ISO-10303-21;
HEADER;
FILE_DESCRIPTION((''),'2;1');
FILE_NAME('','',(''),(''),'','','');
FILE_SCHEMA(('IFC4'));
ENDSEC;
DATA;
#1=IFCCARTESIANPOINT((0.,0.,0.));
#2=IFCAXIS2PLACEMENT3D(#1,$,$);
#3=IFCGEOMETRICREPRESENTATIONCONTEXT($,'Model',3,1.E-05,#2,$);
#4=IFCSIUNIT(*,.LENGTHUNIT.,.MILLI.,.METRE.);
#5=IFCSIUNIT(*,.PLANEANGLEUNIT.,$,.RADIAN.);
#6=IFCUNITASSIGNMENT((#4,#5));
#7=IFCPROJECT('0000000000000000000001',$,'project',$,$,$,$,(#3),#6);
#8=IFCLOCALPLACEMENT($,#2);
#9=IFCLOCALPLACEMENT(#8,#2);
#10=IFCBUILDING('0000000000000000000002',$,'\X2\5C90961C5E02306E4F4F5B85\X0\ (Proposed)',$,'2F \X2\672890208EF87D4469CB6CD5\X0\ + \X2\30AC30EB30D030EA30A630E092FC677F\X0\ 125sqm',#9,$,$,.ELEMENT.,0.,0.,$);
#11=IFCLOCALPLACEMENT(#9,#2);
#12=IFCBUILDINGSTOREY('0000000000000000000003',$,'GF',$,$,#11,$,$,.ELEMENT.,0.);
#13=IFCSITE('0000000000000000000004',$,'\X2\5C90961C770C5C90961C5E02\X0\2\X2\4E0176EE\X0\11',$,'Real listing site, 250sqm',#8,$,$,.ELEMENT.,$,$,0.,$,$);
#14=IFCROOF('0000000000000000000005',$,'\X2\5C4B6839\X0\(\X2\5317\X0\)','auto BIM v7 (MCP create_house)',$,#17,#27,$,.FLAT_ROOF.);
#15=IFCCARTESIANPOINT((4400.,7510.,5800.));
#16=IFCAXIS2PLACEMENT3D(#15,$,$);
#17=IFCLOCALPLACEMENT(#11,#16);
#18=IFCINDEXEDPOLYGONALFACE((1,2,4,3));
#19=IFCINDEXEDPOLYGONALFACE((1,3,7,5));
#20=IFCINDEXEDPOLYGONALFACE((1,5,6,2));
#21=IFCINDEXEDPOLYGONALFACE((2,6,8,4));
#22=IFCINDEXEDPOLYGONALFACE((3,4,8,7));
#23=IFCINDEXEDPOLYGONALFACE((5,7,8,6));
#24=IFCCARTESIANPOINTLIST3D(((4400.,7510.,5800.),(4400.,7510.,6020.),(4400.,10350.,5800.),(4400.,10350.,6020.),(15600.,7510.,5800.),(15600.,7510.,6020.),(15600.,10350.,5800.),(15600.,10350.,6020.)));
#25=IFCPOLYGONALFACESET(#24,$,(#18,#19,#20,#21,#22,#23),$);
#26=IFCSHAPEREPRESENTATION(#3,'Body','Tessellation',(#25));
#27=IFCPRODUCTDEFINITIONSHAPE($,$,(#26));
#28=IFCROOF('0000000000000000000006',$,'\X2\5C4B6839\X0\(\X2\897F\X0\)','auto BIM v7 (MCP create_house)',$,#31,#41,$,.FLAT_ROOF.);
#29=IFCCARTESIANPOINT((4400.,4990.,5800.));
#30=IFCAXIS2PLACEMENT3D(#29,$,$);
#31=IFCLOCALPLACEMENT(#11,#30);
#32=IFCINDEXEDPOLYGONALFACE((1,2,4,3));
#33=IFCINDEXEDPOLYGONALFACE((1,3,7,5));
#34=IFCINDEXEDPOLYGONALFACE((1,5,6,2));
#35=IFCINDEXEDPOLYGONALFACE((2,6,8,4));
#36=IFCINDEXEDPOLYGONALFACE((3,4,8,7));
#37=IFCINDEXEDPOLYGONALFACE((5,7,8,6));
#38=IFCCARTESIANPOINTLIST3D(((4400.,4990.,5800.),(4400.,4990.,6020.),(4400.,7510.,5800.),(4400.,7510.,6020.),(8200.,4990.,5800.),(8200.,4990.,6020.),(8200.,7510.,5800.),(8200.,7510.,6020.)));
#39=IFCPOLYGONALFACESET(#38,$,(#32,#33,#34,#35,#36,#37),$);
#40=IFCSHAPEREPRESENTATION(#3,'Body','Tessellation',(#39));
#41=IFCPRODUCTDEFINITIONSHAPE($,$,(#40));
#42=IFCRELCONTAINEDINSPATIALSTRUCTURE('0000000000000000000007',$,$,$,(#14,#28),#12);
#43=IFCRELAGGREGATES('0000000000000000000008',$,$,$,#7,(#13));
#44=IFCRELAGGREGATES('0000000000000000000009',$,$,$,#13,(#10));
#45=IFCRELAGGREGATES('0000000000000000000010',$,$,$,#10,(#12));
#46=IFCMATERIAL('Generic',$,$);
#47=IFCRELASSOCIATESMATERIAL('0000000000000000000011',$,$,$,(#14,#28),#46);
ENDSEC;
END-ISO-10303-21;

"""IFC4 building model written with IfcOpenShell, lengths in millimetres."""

from ifc_helpers import new_model, si_unit, frame, frame_2d, origin, place, context, project, spatial, rectangle, extrude, material, element, save


model = new_model("IFC4")

# Units and contexts
model_context = context("Model", 3, precision=1e-05, world=origin())
ifc_project = project(units=[si_unit("LENGTHUNIT", "METRE", prefix="MILLI"), si_unit("PLANEANGLEUNIT", "RADIAN")], contexts=[model_context])

# Site, building, storey
site_placement = place(None, origin())
site = spatial("IfcSite", under=ifc_project, at=site_placement, Name="岐阜県岐阜市2丁目11", ObjectType="Real listing site, 250sqm", CompositionType="ELEMENT", RefElevation=0.0)
building_placement = place(site_placement, origin())
building = spatial("IfcBuilding", under=site, at=building_placement, Name="岐阜市の住宅 (Proposed)", ObjectType="2F 木造軸組構法 + ガルバリウム鋼板 125sqm", CompositionType="ELEMENT", ElevationOfRefHeight=0.0, ElevationOfTerrain=0.0)
storey_placement = place(building_placement, origin())
storey = spatial("IfcBuildingStorey", under=building, at=storey_placement, Name="GF", CompositionType="ELEMENT", Elevation=0.0)

# Shared definitions
ifc_material = material(Name="Generic")

# Roofs
roof_1_placement = place(storey_placement, frame((4400.0, 7510.0, 5800.0)))
element("IfcRoof", 1, at=roof_1_placement, inside=storey, material=ifc_material, Name="屋根(北)", Description="auto BIM v7 (MCP create_house)", PredefinedType="FLAT_ROOF", context=model_context, shape_type="SweptSolid", body=[
    extrude(rectangle(XDim=11200.0, YDim=2840.0, at=frame_2d((5600.0, 1420.0))), frame((4400.0, 7510.0, 5800.0)), (0.0, 0.0, 1.0), 220.0),
])
roof_2_placement = place(storey_placement, frame((4400.0, 4990.0, 5800.0)))
element("IfcRoof", 2, at=roof_2_placement, inside=storey, material=ifc_material, Name="屋根(西)", Description="auto BIM v7 (MCP create_house)", PredefinedType="FLAT_ROOF", context=model_context, shape_type="SweptSolid", body=[
    extrude(rectangle(XDim=3800.0, YDim=2520.0, at=frame_2d((1900.0, 1260.0))), frame((4400.0, 4990.0, 5800.0)), (0.0, 0.0, 1.0), 220.0),
])

save(model, "model.ifc")
